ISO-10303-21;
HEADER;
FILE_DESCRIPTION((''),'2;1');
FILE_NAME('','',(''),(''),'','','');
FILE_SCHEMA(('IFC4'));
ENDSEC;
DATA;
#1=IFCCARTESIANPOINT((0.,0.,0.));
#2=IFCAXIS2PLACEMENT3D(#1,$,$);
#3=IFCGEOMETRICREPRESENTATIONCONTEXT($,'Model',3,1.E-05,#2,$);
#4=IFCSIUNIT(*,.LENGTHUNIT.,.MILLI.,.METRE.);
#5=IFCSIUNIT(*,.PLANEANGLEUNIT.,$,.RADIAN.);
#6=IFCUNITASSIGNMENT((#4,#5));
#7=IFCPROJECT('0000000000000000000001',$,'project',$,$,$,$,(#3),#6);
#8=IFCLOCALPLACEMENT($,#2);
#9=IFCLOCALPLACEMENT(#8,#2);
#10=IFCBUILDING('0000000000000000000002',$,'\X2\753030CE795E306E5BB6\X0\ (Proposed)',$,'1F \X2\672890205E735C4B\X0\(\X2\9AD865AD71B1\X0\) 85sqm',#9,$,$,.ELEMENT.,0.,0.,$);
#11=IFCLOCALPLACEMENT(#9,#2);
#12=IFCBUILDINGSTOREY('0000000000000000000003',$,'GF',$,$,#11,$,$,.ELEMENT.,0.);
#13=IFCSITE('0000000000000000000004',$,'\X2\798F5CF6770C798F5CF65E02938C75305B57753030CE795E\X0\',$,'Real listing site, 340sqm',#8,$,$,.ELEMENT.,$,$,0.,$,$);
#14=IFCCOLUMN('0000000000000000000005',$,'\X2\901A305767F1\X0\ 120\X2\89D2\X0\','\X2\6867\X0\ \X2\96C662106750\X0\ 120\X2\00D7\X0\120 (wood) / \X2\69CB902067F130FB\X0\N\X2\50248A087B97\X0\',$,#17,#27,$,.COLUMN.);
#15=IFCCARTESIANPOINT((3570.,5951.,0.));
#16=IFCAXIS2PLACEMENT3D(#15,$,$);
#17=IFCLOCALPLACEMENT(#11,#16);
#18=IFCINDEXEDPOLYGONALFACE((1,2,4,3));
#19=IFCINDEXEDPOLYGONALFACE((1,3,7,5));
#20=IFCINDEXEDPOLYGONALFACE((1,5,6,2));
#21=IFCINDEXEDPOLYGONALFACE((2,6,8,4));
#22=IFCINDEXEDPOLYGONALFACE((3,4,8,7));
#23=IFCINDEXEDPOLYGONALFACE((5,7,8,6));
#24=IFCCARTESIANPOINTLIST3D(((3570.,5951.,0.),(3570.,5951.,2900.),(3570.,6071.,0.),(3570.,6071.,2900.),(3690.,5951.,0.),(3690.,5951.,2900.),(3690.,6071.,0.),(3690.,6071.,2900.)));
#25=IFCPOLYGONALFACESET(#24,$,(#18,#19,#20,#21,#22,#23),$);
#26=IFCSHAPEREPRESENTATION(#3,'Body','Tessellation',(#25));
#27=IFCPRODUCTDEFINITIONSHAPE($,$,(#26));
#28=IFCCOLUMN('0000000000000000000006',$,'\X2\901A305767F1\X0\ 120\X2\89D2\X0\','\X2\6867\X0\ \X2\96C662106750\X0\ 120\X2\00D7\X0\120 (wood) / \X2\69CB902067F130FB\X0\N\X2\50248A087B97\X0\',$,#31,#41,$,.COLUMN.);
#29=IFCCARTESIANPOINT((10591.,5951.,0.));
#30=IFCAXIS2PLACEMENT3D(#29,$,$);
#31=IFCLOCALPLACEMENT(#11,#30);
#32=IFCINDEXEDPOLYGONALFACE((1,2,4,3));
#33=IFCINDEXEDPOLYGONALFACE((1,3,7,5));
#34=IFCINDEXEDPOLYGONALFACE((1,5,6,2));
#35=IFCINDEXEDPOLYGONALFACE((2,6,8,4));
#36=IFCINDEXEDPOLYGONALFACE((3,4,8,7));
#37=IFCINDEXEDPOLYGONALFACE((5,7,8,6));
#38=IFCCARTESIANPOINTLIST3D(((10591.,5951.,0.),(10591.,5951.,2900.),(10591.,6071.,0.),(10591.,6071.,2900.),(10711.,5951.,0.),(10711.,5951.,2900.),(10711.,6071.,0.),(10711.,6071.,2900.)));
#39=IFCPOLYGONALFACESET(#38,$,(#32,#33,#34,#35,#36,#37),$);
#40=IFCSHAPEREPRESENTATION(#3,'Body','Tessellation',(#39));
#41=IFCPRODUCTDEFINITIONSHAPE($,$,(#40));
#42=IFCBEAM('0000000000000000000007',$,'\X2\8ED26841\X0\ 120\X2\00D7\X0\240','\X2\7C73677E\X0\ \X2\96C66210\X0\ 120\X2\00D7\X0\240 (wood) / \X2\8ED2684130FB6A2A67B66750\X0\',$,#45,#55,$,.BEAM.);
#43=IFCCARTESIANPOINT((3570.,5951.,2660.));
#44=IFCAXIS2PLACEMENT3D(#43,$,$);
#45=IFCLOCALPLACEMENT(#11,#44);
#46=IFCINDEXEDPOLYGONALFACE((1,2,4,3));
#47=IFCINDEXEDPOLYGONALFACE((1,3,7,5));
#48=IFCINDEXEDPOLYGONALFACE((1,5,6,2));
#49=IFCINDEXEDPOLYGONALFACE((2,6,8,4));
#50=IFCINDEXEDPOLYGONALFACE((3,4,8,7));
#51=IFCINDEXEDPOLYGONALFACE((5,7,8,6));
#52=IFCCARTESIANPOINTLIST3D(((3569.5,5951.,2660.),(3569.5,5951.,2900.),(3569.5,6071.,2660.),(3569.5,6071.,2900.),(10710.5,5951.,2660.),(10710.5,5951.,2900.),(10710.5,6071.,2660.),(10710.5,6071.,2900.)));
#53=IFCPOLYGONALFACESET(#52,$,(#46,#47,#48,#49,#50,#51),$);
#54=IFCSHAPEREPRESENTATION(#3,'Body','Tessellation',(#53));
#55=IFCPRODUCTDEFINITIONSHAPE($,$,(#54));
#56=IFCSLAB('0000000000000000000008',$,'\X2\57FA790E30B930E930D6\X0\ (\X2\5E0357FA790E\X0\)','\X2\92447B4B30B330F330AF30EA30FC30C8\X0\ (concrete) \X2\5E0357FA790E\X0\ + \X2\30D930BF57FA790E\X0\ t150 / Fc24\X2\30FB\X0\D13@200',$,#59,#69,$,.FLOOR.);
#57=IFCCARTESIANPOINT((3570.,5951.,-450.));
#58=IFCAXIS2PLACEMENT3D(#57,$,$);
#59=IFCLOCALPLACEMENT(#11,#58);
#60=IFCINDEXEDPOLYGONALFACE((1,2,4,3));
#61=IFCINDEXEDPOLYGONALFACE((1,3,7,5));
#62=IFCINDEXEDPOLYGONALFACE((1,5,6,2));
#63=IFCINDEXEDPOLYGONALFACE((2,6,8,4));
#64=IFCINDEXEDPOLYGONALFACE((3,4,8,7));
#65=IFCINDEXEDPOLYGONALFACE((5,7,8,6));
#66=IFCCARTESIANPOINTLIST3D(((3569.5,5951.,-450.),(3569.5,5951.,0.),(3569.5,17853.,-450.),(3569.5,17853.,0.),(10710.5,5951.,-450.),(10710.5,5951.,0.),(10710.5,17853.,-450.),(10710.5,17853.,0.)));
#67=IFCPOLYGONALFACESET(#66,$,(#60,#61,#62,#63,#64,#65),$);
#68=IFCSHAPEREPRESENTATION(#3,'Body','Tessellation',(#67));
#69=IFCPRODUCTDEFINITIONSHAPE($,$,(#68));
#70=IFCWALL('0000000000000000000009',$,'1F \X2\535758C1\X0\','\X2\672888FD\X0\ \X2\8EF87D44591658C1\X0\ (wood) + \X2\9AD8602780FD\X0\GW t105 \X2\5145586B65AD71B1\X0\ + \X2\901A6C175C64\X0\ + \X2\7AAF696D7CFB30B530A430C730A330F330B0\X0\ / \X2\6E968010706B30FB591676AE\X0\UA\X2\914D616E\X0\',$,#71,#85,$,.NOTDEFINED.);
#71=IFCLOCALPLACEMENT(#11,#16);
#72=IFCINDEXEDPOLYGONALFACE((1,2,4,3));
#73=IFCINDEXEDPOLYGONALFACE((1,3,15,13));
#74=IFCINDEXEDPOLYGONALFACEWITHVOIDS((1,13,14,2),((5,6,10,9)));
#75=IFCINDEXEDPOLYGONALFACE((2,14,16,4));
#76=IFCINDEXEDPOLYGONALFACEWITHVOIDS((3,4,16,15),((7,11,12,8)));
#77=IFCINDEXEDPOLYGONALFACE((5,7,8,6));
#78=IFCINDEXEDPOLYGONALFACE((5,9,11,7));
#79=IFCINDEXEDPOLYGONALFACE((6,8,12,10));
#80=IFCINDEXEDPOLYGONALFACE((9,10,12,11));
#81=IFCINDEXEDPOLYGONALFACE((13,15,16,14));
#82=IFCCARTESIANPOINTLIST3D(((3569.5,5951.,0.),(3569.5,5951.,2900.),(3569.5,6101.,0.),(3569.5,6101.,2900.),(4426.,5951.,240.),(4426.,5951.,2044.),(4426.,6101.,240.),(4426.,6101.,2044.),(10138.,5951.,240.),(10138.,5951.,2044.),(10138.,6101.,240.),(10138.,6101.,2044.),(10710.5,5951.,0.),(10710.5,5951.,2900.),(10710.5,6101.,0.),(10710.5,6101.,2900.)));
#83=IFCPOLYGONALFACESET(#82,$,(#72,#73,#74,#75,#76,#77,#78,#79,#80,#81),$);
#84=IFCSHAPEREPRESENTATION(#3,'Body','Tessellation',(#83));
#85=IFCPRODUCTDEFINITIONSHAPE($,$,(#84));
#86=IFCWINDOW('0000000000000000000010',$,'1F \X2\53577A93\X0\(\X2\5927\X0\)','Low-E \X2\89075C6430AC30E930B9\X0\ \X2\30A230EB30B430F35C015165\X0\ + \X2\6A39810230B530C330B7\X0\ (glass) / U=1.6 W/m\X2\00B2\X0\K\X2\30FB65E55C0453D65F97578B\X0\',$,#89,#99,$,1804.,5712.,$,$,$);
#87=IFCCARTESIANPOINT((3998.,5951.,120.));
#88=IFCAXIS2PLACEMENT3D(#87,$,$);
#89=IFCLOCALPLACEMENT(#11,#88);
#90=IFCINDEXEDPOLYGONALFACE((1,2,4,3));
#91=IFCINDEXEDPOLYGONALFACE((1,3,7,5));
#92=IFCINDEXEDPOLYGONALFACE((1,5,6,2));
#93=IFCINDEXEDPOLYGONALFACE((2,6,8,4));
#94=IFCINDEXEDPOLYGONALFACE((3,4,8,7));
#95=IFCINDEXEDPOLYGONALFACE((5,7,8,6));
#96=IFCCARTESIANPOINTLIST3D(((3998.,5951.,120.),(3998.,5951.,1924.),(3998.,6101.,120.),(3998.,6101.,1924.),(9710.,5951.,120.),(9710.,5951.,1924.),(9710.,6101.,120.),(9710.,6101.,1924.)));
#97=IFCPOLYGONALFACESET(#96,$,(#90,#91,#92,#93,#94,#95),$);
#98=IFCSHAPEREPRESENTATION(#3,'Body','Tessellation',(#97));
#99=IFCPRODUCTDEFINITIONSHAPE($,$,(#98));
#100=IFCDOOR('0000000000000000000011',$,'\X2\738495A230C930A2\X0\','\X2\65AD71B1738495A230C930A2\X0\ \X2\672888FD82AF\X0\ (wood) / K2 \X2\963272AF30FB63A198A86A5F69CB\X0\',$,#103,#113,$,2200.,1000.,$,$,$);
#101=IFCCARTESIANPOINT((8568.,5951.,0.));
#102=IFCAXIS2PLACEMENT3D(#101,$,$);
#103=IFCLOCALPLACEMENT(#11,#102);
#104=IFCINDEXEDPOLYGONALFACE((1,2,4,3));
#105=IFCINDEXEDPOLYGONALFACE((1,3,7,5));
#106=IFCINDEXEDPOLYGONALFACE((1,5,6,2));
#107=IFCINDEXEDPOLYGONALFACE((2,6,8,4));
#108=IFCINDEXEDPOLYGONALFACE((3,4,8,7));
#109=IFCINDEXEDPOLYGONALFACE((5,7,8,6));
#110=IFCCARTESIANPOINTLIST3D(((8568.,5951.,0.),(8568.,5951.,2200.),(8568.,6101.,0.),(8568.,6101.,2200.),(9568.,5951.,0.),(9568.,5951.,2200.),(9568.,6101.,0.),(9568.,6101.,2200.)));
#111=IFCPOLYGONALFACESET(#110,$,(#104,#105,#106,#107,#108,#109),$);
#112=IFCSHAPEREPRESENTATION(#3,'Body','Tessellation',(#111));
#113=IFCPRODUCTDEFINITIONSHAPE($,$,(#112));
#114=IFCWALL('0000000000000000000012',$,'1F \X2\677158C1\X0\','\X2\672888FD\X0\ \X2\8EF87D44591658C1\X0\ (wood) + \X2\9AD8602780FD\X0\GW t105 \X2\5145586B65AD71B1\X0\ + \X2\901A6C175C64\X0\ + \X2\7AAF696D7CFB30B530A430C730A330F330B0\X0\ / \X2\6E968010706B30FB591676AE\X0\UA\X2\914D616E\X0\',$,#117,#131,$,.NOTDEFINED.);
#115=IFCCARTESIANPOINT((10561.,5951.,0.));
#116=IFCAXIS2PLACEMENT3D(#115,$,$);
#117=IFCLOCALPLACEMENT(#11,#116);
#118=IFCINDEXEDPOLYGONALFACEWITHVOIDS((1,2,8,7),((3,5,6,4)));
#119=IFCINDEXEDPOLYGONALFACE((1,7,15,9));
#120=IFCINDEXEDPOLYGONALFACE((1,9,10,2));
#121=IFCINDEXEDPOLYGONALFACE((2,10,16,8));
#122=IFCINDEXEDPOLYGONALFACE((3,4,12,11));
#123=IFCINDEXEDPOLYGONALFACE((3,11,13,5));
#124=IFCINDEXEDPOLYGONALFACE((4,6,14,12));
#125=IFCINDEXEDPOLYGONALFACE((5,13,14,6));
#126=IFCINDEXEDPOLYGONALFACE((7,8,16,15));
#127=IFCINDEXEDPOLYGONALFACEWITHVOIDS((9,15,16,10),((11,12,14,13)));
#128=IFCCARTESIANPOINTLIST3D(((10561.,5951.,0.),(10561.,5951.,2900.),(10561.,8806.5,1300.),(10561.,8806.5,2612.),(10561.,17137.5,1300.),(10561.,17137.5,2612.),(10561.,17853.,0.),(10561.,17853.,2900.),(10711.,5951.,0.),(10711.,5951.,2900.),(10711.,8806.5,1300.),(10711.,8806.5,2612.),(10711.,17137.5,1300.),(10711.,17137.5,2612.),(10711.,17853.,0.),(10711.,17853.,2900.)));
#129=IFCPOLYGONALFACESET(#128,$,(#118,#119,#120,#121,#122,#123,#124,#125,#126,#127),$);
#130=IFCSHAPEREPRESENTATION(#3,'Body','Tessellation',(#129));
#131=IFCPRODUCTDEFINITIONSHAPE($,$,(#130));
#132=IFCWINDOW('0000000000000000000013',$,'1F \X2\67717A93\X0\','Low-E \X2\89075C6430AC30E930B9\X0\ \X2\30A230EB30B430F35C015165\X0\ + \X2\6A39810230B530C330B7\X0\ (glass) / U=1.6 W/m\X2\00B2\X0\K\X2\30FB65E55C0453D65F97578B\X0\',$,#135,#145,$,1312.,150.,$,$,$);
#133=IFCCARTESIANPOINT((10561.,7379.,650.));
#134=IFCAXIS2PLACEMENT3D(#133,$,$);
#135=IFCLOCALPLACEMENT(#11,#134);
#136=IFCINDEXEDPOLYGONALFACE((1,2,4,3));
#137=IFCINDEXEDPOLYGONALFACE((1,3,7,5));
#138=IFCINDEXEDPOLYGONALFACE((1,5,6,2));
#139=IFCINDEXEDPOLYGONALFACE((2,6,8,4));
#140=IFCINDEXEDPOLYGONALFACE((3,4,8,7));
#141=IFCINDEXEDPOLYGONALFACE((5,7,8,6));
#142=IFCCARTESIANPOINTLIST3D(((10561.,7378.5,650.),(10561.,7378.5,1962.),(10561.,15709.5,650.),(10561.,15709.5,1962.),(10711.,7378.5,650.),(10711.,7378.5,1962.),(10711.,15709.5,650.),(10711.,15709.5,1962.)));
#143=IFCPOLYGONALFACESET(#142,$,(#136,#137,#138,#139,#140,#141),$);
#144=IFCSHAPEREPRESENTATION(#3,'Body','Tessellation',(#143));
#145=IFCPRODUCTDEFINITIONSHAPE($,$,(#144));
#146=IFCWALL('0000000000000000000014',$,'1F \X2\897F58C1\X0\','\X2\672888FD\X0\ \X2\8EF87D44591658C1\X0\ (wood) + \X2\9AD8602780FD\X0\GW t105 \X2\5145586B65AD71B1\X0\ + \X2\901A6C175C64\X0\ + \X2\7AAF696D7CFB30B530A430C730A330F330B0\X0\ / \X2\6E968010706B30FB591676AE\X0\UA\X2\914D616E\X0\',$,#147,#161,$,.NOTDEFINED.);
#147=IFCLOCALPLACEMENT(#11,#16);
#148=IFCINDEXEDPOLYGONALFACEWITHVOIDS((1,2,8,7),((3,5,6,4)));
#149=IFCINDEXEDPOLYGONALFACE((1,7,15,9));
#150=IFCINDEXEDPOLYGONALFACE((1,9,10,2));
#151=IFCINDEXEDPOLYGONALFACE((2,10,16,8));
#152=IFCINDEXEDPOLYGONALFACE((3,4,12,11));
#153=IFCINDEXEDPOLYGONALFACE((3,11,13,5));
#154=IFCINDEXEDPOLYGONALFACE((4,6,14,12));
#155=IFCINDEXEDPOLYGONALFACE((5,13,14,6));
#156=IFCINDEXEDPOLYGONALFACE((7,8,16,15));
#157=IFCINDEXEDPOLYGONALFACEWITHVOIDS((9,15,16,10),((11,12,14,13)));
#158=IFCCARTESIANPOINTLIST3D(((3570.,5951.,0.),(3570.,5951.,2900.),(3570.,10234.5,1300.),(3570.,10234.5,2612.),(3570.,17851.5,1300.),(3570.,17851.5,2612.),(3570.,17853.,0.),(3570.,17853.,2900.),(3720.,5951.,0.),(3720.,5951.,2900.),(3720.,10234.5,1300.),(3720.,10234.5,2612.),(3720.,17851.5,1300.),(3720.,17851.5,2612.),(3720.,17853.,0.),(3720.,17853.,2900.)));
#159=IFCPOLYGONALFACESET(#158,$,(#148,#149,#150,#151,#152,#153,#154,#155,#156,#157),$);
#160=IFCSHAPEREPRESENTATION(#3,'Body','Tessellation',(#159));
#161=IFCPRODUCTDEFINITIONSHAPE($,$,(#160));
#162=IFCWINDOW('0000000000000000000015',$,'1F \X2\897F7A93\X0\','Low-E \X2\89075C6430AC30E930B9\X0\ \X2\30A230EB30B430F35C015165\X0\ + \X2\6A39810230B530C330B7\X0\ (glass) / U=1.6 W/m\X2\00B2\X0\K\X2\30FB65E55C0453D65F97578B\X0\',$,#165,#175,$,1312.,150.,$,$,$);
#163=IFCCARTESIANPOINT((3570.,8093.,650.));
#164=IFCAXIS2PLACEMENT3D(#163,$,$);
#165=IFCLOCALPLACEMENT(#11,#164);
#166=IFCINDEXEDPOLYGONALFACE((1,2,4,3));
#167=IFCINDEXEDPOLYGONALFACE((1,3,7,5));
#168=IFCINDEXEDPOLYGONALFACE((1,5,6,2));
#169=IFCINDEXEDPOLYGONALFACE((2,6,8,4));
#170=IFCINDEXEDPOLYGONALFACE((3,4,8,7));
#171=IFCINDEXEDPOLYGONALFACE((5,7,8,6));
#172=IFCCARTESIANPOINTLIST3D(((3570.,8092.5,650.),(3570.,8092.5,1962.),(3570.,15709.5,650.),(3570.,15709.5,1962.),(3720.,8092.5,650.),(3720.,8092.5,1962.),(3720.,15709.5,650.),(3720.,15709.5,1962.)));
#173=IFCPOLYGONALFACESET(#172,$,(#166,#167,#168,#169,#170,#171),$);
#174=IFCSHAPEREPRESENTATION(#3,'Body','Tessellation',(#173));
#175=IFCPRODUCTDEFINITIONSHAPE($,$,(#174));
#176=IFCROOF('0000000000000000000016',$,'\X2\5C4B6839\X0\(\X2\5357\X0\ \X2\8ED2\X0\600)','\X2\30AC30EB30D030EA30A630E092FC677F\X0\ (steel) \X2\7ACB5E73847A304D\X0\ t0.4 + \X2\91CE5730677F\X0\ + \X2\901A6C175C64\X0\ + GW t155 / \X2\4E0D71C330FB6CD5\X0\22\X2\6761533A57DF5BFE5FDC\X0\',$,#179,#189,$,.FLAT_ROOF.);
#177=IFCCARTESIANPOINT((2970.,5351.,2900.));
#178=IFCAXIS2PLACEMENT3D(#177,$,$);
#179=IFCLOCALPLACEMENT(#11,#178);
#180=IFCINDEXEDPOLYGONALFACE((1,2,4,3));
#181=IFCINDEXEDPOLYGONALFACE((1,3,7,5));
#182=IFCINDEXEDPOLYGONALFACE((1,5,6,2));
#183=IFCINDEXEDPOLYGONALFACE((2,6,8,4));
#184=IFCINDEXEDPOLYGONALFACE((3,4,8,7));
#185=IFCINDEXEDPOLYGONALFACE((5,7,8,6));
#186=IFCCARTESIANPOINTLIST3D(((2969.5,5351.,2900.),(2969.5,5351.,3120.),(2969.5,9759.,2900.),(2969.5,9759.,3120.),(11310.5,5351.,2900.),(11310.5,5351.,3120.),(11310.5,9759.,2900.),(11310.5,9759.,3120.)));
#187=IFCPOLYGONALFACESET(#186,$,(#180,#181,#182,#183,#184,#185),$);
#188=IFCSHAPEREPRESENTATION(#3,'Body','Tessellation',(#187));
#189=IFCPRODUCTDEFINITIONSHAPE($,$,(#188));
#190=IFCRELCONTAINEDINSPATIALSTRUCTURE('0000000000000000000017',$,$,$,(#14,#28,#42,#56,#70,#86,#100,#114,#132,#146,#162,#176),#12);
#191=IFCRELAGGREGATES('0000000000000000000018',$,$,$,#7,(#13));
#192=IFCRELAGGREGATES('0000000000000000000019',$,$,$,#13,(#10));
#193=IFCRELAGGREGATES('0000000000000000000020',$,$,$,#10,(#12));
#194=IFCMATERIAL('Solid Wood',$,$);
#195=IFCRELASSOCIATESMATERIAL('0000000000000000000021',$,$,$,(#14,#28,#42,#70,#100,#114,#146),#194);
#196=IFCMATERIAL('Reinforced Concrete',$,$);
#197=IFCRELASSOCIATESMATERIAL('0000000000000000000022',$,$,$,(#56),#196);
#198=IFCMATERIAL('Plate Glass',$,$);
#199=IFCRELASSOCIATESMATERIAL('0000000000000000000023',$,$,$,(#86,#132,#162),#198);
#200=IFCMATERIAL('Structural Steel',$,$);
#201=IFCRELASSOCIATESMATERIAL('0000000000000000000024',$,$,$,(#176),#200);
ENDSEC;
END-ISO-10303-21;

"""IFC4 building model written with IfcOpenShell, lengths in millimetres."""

from ifc_helpers import new_model, si_unit, frame, frame_2d, origin, place, context, project, spatial, rectangle, extrude, material, element, fill, save


model = new_model("IFC4")

# Units and contexts
model_context = context("Model", 3, precision=1e-05, world=origin())
ifc_project = project(units=[si_unit("LENGTHUNIT", "METRE", prefix="MILLI"), si_unit("PLANEANGLEUNIT", "RADIAN")], contexts=[model_context])

# Site, building, storey
site_placement = place(None, origin())
site = spatial("IfcSite", under=ifc_project, at=site_placement, Name="福島県福島市鎌田字田ノ神", ObjectType="Real listing site, 340sqm", CompositionType="ELEMENT", RefElevation=0.0)
building_placement = place(site_placement, origin())
building = spatial("IfcBuilding", under=site, at=building_placement, Name="田ノ神の家 (Proposed)", ObjectType="1F 木造平屋(高断熱) 85sqm", CompositionType="ELEMENT", ElevationOfRefHeight=0.0, ElevationOfTerrain=0.0)
storey_placement = place(building_placement, origin())
storey = spatial("IfcBuildingStorey", under=building, at=storey_placement, Name="GF", CompositionType="ELEMENT", Elevation=0.0)

# Columns
ifc_material_1 = material(Name="Solid Wood")
column_1_placement = place(storey_placement, frame((3570.0, 5951.0, 0.0)))
element("IfcColumn", 1, at=column_1_placement, inside=storey, material=ifc_material_1, Name="通し柱 120角", Description="桧 集成材 120×120 (wood) / 構造柱・N値計算", PredefinedType="COLUMN", context=model_context, shape_type="SweptSolid", body=[
    extrude(rectangle(XDim=120.0, YDim=120.0, at=frame_2d((60.0, 60.0))), frame((3570.0, 5951.0, 0.0)), (0.0, 0.0, 1.0), 2900.0),
])
column_2_placement = place(storey_placement, frame((10591.0, 5951.0, 0.0)))
element("IfcColumn", 2, at=column_2_placement, inside=storey, material=ifc_material_1, Name="通し柱 120角", Description="桧 集成材 120×120 (wood) / 構造柱・N値計算", PredefinedType="COLUMN", context=model_context, shape_type="SweptSolid", body=[
    extrude(rectangle(XDim=120.0, YDim=120.0, at=frame_2d((60.0, 60.0))), frame((10591.0, 5951.0, 0.0)), (0.0, 0.0, 1.0), 2900.0),
])

# Beam
beam_1_placement = place(storey_placement, frame((3570.0, 5951.0, 2660.0)))
element("IfcBeam", 3, at=beam_1_placement, inside=storey, material=ifc_material_1, Name="軒桁 120×240", Description="米松 集成 120×240 (wood) / 軒桁・横架材", PredefinedType="BEAM", context=model_context, shape_type="SweptSolid", body=[
    extrude(rectangle(XDim=7141.0, YDim=120.0, at=frame_2d((3570.0, 60.0))), frame((3570.0, 5951.0, 2660.0)), (0.0, 0.0, 1.0), 240.0),
])

# Slab
ifc_material_2 = material(Name="Reinforced Concrete")
slab_1_placement = place(storey_placement, frame((3570.0, 5951.0, -450.0)))
element("IfcSlab", 4, at=slab_1_placement, inside=storey, material=ifc_material_2, Name="基礎スラブ (布基礎)", Description="鉄筋コンクリート (concrete) 布基礎 + ベタ基礎 t150 / Fc24・D13@200", PredefinedType="FLOOR", context=model_context, shape_type="SweptSolid", body=[
    extrude(rectangle(XDim=7141.0, YDim=11902.0, at=frame_2d((3570.0, 5951.0))), frame((3570.0, 5951.0, -450.0)), (0.0, 0.0, 1.0), 450.0),
])

# Wall, openings, window, door
wall_1_placement = place(storey_placement, frame((3570.0, 5951.0, 0.0)))
wall_1 = element("IfcWall", 5, at=wall_1_placement, inside=storey, material=ifc_material_1, Name="1F 南壁", Description="木製 軸組外壁 (wood) + 高性能GW t105 充填断熱 + 通気層 + 窯業系サイディング / 準耐火・外皮UA配慮", PredefinedType="NOTDEFINED", context=model_context, shape_type="SweptSolid", body=[
    extrude(rectangle(XDim=7141.0, YDim=150.0, at=frame_2d((3570.0, 75.0))), frame((3570.0, 5951.0, 0.0)), (0.0, 0.0, 1.0), 2900.0),
])
opening_1_placement = place(storey_placement, frame((3998.0, 5951.0, 120.0)))
opening_1 = element("IfcOpeningElement", 6, at=opening_1_placement, cuts=wall_1, PredefinedType="NOTDEFINED", context=model_context, shape_type="SweptSolid", body=[
    extrude(rectangle(XDim=5712.0, YDim=150.0, at=frame_2d((2856.0, 75.0))), frame((3998.0, 5951.0, 120.0)), (0.0, 0.0, 1.0), 1804.0),
])
opening_2_placement = place(storey_placement, frame((8568.0, 5951.0, 0.0)))
opening_2 = element("IfcOpeningElement", 7, at=opening_2_placement, cuts=wall_1, PredefinedType="NOTDEFINED", context=model_context, shape_type="SweptSolid", body=[
    extrude(rectangle(XDim=1000.0, YDim=150.0, at=frame_2d((500.0, 75.0))), frame((8568.0, 5951.0, 0.0)), (0.0, 0.0, 1.0), 2200.0),
])
ifc_material_3 = material(Name="Plate Glass")
window_1_placement = place(storey_placement, frame((3998.0, 5951.0, 120.0)))
window_1 = element("IfcWindow", 8, at=window_1_placement, inside=storey, material=ifc_material_3, Name="1F 南窓(大)", Description="Low-E 複層ガラス アルゴン封入 + 樹脂サッシ (glass) / U=1.6 W/m²K・日射取得型", OverallHeight=1804.0, OverallWidth=5712.0, context=model_context, shape_type="SweptSolid", body=[
    extrude(rectangle(XDim=5712.0, YDim=150.0, at=frame_2d((2856.0, 75.0))), frame((3998.0, 5951.0, 120.0)), (0.0, 0.0, 1.0), 1804.0),
])
fill(opening_1, window_1)
door_placement = place(storey_placement, frame((8568.0, 5951.0, 0.0)))
door = element("IfcDoor", 9, at=door_placement, inside=storey, material=ifc_material_1, Name="玄関ドア", Description="断熱玄関ドア 木製芯 (wood) / K2 防犯・採風機構", OverallHeight=2200.0, OverallWidth=1000.0, context=model_context, shape_type="SweptSolid", body=[
    extrude(rectangle(XDim=1000.0, YDim=150.0, at=frame_2d((500.0, 75.0))), frame((8568.0, 5951.0, 0.0)), (0.0, 0.0, 1.0), 2200.0),
])
fill(opening_2, door)

# Walls, openings, windows
wall_2_placement = place(storey_placement, frame((10561.0, 5951.0, 0.0)))
wall_2 = element("IfcWall", 10, at=wall_2_placement, inside=storey, material=ifc_material_1, Name="1F 東壁", Description="木製 軸組外壁 (wood) + 高性能GW t105 充填断熱 + 通気層 + 窯業系サイディング / 準耐火・外皮UA配慮", PredefinedType="NOTDEFINED", context=model_context, shape_type="SweptSolid", body=[
    extrude(rectangle(XDim=150.0, YDim=11902.0, at=frame_2d((75.0, 5951.0))), frame((10561.0, 5951.0, 0.0)), (0.0, 0.0, 1.0), 2900.0),
])
opening_3_placement = place(storey_placement, frame((10561.0, 7379.0, 650.0)))
opening_3 = element("IfcOpeningElement", 11, at=opening_3_placement, cuts=wall_2, PredefinedType="NOTDEFINED", context=model_context, shape_type="SweptSolid", body=[
    extrude(rectangle(XDim=150.0, YDim=8331.0, at=frame_2d((75.0, 4165.0))), frame((10561.0, 7379.0, 650.0)), (0.0, 0.0, 1.0), 1312.0),
])
window_2_placement = place(storey_placement, frame((10561.0, 7379.0, 650.0)))
window_2 = element("IfcWindow", 12, at=window_2_placement, inside=storey, material=ifc_material_3, Name="1F 東窓", Description="Low-E 複層ガラス アルゴン封入 + 樹脂サッシ (glass) / U=1.6 W/m²K・日射取得型", OverallHeight=1312.0, OverallWidth=150.0, context=model_context, shape_type="SweptSolid", body=[
    extrude(rectangle(XDim=150.0, YDim=8331.0, at=frame_2d((75.0, 4165.0))), frame((10561.0, 7379.0, 650.0)), (0.0, 0.0, 1.0), 1312.0),
])
fill(opening_3, window_2)
wall_3_placement = place(storey_placement, frame((3570.0, 5951.0, 0.0)))
wall_3 = element("IfcWall", 13, at=wall_3_placement, inside=storey, material=ifc_material_1, Name="1F 西壁", Description="木製 軸組外壁 (wood) + 高性能GW t105 充填断熱 + 通気層 + 窯業系サイディング / 準耐火・外皮UA配慮", PredefinedType="NOTDEFINED", context=model_context, shape_type="SweptSolid", body=[
    extrude(rectangle(XDim=150.0, YDim=11902.0, at=frame_2d((75.0, 5951.0))), frame((3570.0, 5951.0, 0.0)), (0.0, 0.0, 1.0), 2900.0),
])
opening_4_placement = place(storey_placement, frame((3570.0, 8093.0, 650.0)))
opening_4 = element("IfcOpeningElement", 14, at=opening_4_placement, cuts=wall_3, PredefinedType="NOTDEFINED", context=model_context, shape_type="SweptSolid", body=[
    extrude(rectangle(XDim=150.0, YDim=7617.0, at=frame_2d((75.0, 3808.0))), frame((3570.0, 8093.0, 650.0)), (0.0, 0.0, 1.0), 1312.0),
])
window_3_placement = place(storey_placement, frame((3570.0, 8093.0, 650.0)))
window_3 = element("IfcWindow", 15, at=window_3_placement, inside=storey, material=ifc_material_3, Name="1F 西窓", Description="Low-E 複層ガラス アルゴン封入 + 樹脂サッシ (glass) / U=1.6 W/m²K・日射取得型", OverallHeight=1312.0, OverallWidth=150.0, context=model_context, shape_type="SweptSolid", body=[
    extrude(rectangle(XDim=150.0, YDim=7617.0, at=frame_2d((75.0, 3808.0))), frame((3570.0, 8093.0, 650.0)), (0.0, 0.0, 1.0), 1312.0),
])
fill(opening_4, window_3)

# Roof
ifc_material_4 = material(Name="Structural Steel")
roof_placement = place(storey_placement, frame((2970.0, 5351.0, 2900.0)))
element("IfcRoof", 16, at=roof_placement, inside=storey, material=ifc_material_4, Name="屋根(南 軒600)", Description="ガルバリウム鋼板 (steel) 立平葺き t0.4 + 野地板 + 通気層 + GW t155 / 不燃・法22条区域対応", PredefinedType="FLAT_ROOF", context=model_context, shape_type="SweptSolid", body=[
    extrude(rectangle(XDim=8341.0, YDim=4408.0, at=frame_2d((4170.0, 2204.0))), frame((2970.0, 5351.0, 2900.0)), (0.0, 0.0, 1.0), 220.0),
])

save(model, "model.ifc")
